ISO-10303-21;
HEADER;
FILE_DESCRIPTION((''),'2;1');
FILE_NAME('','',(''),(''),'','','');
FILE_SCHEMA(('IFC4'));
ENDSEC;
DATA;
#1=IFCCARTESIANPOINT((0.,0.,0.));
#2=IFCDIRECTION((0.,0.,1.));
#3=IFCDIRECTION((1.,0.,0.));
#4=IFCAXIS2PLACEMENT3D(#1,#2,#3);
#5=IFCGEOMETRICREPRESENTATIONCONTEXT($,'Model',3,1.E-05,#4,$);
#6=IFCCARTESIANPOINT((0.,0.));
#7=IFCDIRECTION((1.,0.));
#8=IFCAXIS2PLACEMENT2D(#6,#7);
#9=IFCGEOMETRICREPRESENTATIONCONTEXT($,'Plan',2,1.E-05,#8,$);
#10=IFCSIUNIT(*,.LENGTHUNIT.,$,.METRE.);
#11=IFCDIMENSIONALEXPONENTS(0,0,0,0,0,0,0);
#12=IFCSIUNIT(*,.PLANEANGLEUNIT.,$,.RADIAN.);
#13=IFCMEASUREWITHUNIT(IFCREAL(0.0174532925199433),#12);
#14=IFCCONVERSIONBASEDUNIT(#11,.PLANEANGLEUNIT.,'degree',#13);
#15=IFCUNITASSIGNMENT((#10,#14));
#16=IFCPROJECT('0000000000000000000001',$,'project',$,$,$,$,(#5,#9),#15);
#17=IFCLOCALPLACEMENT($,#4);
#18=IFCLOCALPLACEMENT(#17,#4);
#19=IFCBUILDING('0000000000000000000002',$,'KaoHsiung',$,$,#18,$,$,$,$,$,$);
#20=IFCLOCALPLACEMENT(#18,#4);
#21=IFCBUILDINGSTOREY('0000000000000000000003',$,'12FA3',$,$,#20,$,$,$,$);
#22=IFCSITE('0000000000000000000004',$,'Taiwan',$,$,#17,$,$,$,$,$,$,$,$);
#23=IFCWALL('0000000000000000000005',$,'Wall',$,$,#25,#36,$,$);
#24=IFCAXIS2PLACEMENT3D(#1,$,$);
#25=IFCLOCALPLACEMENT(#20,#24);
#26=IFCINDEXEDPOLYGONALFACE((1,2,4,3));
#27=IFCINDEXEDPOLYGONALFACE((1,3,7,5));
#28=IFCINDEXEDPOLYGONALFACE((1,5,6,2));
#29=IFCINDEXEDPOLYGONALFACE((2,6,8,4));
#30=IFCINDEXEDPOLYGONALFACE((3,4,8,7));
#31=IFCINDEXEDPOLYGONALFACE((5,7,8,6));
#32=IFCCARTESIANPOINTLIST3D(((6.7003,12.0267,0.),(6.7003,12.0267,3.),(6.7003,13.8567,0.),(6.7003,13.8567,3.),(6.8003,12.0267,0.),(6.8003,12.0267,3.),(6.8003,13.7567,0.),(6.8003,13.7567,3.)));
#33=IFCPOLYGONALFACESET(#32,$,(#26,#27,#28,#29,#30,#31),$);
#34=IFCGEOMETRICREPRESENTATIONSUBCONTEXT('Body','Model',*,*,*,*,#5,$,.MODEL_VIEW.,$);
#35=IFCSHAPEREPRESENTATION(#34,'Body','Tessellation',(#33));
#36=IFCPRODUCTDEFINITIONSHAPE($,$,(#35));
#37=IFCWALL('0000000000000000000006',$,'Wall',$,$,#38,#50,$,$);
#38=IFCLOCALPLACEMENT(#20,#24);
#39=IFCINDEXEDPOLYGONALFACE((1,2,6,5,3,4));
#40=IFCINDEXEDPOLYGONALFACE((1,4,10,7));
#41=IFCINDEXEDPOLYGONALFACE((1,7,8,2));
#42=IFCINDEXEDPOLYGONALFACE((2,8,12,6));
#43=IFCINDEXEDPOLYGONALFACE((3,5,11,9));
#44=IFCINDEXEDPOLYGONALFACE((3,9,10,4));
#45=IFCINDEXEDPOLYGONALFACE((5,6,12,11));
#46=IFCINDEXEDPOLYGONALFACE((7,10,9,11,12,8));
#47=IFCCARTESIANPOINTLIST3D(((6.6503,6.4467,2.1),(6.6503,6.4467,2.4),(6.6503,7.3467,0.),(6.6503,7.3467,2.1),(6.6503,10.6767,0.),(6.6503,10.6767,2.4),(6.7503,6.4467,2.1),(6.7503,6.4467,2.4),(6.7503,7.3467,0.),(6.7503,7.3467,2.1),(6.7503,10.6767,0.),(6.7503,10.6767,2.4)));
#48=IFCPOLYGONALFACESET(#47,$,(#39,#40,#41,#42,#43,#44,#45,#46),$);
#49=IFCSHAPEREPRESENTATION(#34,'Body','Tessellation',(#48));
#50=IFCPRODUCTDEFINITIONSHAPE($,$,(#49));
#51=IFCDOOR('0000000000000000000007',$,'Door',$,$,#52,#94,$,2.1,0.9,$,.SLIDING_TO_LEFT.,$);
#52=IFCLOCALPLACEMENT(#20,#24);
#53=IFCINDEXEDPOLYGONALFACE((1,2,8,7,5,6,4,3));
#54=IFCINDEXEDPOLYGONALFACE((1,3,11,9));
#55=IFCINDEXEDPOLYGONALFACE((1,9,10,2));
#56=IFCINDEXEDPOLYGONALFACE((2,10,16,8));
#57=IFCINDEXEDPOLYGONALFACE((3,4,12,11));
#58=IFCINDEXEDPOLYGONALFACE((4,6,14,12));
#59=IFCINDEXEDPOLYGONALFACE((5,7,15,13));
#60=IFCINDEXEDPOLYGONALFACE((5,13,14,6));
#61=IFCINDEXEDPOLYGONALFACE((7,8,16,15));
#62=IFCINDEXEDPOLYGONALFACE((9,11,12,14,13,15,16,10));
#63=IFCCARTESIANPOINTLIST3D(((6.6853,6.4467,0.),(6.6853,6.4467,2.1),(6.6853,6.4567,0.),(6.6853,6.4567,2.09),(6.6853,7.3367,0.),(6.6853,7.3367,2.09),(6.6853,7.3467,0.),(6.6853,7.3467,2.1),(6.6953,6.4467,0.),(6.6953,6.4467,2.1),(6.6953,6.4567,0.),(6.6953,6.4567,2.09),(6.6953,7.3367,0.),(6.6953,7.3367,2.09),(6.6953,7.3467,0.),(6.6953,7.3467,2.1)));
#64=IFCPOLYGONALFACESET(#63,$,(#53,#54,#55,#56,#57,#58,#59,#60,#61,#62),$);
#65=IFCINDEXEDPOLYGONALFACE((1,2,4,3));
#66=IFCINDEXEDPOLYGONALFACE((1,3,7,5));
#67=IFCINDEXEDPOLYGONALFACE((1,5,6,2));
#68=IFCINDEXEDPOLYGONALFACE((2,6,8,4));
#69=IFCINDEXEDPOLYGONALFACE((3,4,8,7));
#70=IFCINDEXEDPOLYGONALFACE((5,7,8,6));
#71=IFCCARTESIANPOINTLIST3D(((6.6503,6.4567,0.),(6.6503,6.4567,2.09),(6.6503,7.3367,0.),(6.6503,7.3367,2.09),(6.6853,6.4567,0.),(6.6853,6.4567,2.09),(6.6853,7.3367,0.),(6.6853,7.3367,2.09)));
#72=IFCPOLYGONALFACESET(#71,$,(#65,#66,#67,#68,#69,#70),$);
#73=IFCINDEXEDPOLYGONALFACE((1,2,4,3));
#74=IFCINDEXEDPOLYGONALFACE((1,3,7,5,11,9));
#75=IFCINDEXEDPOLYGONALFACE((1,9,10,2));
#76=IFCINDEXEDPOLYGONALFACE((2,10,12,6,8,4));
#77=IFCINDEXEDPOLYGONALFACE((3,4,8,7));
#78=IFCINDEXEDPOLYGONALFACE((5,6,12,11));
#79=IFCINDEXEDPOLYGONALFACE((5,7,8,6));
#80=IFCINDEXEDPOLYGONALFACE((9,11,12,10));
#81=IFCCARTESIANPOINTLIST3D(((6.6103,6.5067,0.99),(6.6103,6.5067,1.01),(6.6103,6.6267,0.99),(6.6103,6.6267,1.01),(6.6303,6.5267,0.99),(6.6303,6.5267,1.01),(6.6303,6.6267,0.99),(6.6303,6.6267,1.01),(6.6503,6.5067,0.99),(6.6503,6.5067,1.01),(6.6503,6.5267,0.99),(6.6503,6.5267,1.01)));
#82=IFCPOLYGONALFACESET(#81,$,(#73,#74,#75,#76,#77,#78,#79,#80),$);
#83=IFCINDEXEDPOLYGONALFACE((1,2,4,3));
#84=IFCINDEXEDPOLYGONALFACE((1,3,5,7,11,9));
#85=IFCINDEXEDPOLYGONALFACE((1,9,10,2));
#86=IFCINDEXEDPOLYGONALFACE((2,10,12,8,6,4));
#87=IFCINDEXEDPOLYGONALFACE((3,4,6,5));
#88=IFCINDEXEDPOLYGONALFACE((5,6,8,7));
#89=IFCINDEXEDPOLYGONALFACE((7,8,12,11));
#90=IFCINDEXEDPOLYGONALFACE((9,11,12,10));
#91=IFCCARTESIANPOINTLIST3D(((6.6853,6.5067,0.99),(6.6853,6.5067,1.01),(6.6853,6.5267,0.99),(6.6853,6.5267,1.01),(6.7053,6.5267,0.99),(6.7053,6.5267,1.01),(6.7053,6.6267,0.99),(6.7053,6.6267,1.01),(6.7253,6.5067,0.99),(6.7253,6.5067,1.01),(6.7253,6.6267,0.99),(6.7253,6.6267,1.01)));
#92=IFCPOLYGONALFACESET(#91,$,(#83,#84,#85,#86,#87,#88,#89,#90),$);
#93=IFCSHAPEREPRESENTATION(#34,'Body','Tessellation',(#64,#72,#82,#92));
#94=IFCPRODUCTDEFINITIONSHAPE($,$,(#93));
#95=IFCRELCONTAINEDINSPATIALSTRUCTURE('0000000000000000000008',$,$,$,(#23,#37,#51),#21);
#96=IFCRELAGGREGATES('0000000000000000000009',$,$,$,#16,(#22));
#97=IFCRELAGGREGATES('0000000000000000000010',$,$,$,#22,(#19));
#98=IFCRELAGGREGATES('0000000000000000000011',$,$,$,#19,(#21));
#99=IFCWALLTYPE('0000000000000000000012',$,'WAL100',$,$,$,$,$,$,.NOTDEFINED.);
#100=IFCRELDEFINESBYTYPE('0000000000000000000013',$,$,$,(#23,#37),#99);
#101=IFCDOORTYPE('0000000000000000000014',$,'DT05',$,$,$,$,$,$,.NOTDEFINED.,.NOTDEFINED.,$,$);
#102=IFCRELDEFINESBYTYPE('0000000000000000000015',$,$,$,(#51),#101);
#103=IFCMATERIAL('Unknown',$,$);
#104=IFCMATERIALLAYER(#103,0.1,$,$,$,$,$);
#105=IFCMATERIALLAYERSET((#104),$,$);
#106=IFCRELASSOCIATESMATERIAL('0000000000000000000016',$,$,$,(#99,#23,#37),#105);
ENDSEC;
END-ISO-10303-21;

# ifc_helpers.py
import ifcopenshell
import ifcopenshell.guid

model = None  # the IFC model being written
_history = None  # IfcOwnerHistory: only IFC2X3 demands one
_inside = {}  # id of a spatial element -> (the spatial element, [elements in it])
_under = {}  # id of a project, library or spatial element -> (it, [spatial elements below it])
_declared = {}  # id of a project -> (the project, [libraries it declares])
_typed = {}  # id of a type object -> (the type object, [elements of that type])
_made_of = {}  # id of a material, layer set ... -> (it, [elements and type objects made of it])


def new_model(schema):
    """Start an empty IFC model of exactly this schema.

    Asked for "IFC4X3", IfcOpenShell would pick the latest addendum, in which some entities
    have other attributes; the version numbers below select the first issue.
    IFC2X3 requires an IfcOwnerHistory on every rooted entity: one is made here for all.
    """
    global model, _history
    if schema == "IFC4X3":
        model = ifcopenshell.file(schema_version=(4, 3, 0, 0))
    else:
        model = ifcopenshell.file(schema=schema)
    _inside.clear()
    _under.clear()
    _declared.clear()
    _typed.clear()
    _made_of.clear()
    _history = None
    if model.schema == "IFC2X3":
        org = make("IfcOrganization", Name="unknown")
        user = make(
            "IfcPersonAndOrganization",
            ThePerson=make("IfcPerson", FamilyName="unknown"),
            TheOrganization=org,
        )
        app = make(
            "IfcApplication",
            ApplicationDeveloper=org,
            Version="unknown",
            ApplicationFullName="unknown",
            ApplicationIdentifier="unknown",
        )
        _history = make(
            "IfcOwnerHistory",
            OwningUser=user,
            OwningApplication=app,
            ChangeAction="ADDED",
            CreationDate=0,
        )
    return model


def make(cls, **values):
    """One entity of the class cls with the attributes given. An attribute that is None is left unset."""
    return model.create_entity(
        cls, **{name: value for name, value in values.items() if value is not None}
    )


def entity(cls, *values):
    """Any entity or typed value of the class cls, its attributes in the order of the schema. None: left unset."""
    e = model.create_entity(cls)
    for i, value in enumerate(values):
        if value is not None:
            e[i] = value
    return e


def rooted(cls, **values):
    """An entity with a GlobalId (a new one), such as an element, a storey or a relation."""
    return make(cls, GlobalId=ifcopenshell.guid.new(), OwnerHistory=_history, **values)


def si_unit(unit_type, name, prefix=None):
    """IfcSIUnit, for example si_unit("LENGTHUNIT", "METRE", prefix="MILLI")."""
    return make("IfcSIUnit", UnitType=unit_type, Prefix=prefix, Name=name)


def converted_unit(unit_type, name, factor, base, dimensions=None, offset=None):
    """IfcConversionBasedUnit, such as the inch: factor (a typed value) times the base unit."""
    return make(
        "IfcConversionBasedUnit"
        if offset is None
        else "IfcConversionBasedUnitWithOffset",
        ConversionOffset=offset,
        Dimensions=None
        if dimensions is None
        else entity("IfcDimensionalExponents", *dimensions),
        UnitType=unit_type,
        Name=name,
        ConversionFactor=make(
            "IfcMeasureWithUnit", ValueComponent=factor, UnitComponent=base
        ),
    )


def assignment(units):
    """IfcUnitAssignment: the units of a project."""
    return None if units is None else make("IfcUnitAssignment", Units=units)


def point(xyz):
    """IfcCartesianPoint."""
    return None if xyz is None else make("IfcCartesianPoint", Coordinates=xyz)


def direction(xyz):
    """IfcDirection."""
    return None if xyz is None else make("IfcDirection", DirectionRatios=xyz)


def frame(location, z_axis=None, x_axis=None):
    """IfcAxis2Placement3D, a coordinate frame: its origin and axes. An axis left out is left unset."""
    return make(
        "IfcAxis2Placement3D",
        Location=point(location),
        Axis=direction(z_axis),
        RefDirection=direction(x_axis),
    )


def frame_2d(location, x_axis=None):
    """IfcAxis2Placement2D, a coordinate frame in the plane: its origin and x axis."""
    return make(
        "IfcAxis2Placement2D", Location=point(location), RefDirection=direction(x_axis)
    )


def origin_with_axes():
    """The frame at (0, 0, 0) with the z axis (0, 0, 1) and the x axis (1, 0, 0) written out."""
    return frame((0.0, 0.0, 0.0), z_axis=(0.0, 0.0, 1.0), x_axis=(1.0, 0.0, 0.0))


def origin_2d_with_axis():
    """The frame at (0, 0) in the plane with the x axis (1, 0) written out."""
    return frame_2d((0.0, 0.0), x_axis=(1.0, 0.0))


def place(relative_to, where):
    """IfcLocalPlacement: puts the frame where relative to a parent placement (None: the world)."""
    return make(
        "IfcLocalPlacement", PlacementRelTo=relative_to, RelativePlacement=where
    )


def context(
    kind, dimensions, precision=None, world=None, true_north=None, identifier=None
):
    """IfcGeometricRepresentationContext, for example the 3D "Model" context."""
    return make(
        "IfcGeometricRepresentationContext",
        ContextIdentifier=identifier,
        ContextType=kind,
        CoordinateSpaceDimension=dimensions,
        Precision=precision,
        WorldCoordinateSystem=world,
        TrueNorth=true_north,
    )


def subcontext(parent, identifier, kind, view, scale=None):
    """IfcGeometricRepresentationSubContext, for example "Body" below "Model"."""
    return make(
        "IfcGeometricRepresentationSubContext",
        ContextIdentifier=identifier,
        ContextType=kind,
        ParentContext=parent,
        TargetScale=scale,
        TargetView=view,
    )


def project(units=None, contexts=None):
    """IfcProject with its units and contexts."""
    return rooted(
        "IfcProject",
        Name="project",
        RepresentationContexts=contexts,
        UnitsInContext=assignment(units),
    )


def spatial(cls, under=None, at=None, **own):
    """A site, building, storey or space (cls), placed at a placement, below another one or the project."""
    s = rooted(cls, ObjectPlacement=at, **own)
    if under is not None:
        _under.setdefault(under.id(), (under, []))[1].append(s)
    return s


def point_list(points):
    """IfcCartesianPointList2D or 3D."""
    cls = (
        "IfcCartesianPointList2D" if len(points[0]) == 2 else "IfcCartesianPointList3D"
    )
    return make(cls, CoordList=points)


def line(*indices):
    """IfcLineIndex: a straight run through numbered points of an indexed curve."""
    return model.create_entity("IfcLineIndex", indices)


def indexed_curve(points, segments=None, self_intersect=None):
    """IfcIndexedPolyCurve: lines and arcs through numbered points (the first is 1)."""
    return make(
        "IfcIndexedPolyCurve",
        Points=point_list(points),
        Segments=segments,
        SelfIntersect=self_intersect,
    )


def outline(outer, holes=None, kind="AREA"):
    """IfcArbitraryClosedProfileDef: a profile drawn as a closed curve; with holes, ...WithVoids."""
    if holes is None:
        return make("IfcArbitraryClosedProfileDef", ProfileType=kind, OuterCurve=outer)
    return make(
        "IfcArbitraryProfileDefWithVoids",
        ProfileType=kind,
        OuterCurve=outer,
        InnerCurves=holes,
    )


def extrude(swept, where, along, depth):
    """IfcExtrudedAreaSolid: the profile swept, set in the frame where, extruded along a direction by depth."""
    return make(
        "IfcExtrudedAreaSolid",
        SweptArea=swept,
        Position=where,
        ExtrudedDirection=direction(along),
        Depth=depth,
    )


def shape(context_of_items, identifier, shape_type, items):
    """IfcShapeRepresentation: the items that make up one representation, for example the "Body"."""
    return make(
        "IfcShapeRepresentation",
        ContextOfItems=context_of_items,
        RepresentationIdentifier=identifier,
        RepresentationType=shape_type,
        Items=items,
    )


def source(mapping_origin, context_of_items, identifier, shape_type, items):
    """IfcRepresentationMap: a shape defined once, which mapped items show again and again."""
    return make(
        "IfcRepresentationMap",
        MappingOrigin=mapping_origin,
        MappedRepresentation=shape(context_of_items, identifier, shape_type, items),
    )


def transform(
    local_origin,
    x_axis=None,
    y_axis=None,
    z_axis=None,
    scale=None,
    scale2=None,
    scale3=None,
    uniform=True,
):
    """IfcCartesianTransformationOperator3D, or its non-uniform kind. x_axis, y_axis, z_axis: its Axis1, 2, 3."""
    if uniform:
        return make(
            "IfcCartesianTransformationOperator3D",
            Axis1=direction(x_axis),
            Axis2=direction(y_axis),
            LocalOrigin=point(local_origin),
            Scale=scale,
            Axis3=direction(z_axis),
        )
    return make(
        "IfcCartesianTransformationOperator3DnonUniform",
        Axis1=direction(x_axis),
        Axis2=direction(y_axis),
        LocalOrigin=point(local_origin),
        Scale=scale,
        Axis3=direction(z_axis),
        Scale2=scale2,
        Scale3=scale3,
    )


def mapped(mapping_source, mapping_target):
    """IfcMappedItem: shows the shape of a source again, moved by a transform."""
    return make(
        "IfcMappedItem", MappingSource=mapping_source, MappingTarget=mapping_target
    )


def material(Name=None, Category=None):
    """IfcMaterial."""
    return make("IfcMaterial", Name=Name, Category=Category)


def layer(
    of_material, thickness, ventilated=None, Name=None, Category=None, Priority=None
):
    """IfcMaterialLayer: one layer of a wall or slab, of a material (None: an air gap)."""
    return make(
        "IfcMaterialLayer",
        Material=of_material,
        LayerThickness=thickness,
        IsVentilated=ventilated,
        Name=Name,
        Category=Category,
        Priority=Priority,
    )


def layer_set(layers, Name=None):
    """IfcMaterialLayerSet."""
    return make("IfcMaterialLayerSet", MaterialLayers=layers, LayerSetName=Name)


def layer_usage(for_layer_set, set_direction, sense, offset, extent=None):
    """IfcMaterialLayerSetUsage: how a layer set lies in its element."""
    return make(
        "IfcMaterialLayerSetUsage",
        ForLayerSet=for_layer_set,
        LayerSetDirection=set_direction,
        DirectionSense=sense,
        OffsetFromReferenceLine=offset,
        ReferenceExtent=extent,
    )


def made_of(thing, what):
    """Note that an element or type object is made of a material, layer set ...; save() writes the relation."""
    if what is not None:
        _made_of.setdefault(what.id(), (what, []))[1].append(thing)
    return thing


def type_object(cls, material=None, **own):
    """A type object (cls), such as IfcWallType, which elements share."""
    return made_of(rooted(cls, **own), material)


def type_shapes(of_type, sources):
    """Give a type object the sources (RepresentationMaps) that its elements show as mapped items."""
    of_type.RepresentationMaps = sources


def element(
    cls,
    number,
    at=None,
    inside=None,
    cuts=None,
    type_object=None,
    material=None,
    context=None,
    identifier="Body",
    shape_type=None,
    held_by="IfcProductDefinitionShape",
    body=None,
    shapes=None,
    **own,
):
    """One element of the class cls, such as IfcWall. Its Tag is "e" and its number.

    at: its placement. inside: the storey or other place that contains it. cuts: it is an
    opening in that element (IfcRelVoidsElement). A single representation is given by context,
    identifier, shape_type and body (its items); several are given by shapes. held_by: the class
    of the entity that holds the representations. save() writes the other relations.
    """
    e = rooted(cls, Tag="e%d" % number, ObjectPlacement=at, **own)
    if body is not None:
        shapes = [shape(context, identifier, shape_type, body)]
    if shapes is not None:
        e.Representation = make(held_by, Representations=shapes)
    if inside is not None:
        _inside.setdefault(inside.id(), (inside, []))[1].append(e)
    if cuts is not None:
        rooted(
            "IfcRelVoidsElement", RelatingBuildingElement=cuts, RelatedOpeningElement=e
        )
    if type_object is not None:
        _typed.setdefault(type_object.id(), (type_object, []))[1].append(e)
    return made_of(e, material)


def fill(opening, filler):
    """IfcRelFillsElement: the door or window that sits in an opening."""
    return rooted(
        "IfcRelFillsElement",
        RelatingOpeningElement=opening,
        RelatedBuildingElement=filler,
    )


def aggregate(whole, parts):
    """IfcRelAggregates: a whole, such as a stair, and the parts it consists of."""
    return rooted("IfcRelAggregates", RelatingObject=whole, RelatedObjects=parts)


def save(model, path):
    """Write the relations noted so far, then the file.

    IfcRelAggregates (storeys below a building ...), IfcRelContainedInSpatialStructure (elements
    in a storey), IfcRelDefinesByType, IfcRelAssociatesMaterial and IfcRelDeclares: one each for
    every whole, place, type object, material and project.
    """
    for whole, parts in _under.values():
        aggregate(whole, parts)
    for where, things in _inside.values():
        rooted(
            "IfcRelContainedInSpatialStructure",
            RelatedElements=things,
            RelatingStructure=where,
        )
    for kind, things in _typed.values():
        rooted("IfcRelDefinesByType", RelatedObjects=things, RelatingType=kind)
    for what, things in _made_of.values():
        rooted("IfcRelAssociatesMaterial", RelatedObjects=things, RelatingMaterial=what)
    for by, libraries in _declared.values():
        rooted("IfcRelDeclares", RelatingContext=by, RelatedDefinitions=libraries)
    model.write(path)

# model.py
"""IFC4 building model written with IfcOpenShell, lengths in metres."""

from ifc_helpers import new_model, entity, si_unit, converted_unit, frame, origin_with_axes, origin_2d_with_axis, place, context, subcontext, project, spatial, line, indexed_curve, outline, extrude, shape, source, transform, mapped, material, layer, layer_set, layer_usage, type_object, type_shapes, element, fill, save


model = new_model("IFC4")

# Units and contexts
model_context = context("Model", 3, precision=1e-05, world=origin_with_axes())
plan_context = context("Plan", 2, precision=1e-05, world=origin_2d_with_axis())
body_context_1 = subcontext(model_context, "Body", "Model", "MODEL_VIEW")
body_context_2 = subcontext(plan_context, "Body", "Plan", "PLAN_VIEW")
ifc_project = project(units=[si_unit("LENGTHUNIT", "METRE"), converted_unit("PLANEANGLEUNIT", "degree", entity("IfcReal", 0.0174532925199433), si_unit("PLANEANGLEUNIT", "RADIAN"), dimensions=[0, 0, 0, 0, 0, 0, 0])], contexts=[model_context, plan_context])

# Site, building, storey
site_placement = place(None, origin_with_axes())
site = spatial("IfcSite", under=ifc_project, at=site_placement, Name="Taiwan")
building_placement = place(site_placement, origin_with_axes())
building = spatial("IfcBuilding", under=site, at=building_placement, Name="KaoHsiung")
storey_placement = place(building_placement, origin_with_axes())
storey = spatial("IfcBuildingStorey", under=building, at=storey_placement, Name="12FA3")

# Shared definitions
ifc_material = material(Name="Unknown")

# Wall
ifc_layer_1 = layer(ifc_material, 0.1)
ifc_layer_set_1 = layer_set([ifc_layer_1])
wall_type_1 = type_object("IfcWallType", Name="WAL100", PredefinedType="NOTDEFINED", material=ifc_layer_set_1)
ifc_layer_usage_1 = layer_usage(ifc_layer_set_1, "AXIS2", "POSITIVE", 0.0)
wall_1_placement = place(storey_placement, frame((6.7003, 13.8567, 0.0), z_axis=(0.0, 0.0, 1.0), x_axis=(0.0, -1.0, 0.0)))
element("IfcWall", 1, at=wall_1_placement, inside=storey, type_object=wall_type_1, material=ifc_layer_usage_1, Name="Wall", context=body_context_1, shape_type="SweptSolid", body=[
    extrude(outline(indexed_curve([(0.0, 0.0), (0.1, 0.1), (1.8299, 0.1), (1.8299, 0.0)], segments=[line(1, 2, 3, 4, 1)])), origin_with_axes(), (0.0, 0.0, 1.0), 3.0),
])

# Wall, opening, door
ifc_layer_usage_2 = layer_usage(ifc_layer_set_1, "AXIS2", "POSITIVE", 0.0)
wall_2_placement = place(storey_placement, frame((6.6503, 10.6767, 0.0), z_axis=(0.0, 0.0, 1.0), x_axis=(0.0, -1.0, 0.0)))
wall_2 = element("IfcWall", 2, at=wall_2_placement, inside=storey, type_object=wall_type_1, material=ifc_layer_usage_2, Name="Wall", context=body_context_1, shape_type="SweptSolid", body=[
    extrude(outline(indexed_curve([(0.0, 0.0), (0.0, 0.1), (4.23, 0.1), (4.23, 0.0)], segments=[line(1, 2, 3, 4, 1)])), origin_with_axes(), (0.0, 0.0, 1.0), 2.4),
])
shared_shape_1 = source(origin_with_axes(), body_context_1, "Body", "SweptSolid", [
    extrude(outline(indexed_curve([(0.0, 0.0), (0.9, 0.0), (0.9, 2.1), (0.0, 2.1)], segments=[line(1, 2, 3, 4, 1)])), frame((0.0, -0.6, 0.0), z_axis=(0.0, -1.0, 0.0), x_axis=(1.0, 0.0, 0.0)), (0.0, 0.0, -1.0), 1.2),
])
opening_1_placement = place(wall_2_placement, frame((3.33, 0.0, 0.0), z_axis=(0.0, 0.0, 1.0), x_axis=(1.0, 0.0, 0.0)))
opening_1 = element("IfcOpeningElement", 3, at=opening_1_placement, cuts=wall_2, PredefinedType="OPENING", context=body_context_1, shape_type="MappedRepresentation", body=[
    mapped(shared_shape_1, transform((0.0, 0.0, 0.0), x_axis=(1.0, 0.0, 0.0), y_axis=(0.0, 1.0, 0.0), z_axis=(0.0, 0.0, 1.0), scale=1.0)),
])
door_type_1 = type_object("IfcDoorType", Name="DT05", OperationType="NOTDEFINED", PredefinedType="NOTDEFINED")
shared_shape_2 = source(origin_with_axes(), body_context_1, "Body", "SweptSolid", [
    extrude(outline(indexed_curve([(0.0, 0.0), (0.0, 2.1), (0.9, 2.1), (0.9, 0.0), (0.89, 0.0), (0.89, 2.09), (0.01, 2.09), (0.01, 0.0)], segments=[line(1, 2, 3, 4, 5, 6, 7, 8, 1)])), frame((0.0, 0.035, 0.0), z_axis=(0.0, -1.0, 0.0), x_axis=(1.0, 0.0, 0.0)), (0.0, 0.0, -1.0), 0.01),
    extrude(outline(indexed_curve([(0.0, 0.0), (0.88, 0.0), (0.88, 0.035), (0.0, 0.035)], segments=[line(1, 2, 3, 4, 1)])), frame((0.01, 0.0, 0.0), z_axis=(0.0, 0.0, 1.0), x_axis=(1.0, 0.0, 0.0)), (0.0, 0.0, 1.0), 2.09),
    extrude(outline(indexed_curve([(0.0, 0.0), (0.0, -0.04), (-0.12, -0.04), (-0.12, -0.02), (-0.02, -0.02), (-0.02, 0.0)], segments=[line(1, 2, 3, 4, 5, 6, 1)])), frame((0.84, 0.0, 0.99), z_axis=(0.0, 0.0, 1.0), x_axis=(1.0, 0.0, 0.0)), (0.0, 0.0, 1.0), 0.02),
    extrude(outline(indexed_curve([(0.0, 0.0), (0.0, 0.04), (-0.12, 0.04), (-0.12, 0.02), (-0.02, 0.02), (-0.02, 0.0)], segments=[line(1, 2, 3, 4, 5, 6, 1)])), frame((0.84, 0.035, 0.99), z_axis=(0.0, 0.0, 1.0), x_axis=(1.0, 0.0, 0.0)), (0.0, 0.0, 1.0), 0.02),
])
shared_shape_3 = source(origin_with_axes(), body_context_2, "Body", "Curve2D", [
    entity("IfcIndexedPolyCurve", entity("IfcCartesianPointList2D", [[0.0, 0.035], [0.01, 0.035], [0.01, 0.045], [0.0, 0.045]]), [entity("IfcLineIndex", [1, 2, 3, 4, 1])]),
    entity("IfcIndexedPolyCurve", entity("IfcCartesianPointList2D", [[0.9, 0.035], [0.89, 0.035], [0.89, 0.045], [0.9, 0.045]]), [entity("IfcLineIndex", [1, 2, 3, 4, 1])]),
    entity("IfcIndexedPolyCurve", entity("IfcCartesianPointList2D", [[-0.43, 0.0], [0.45, 0.0], [0.45, 0.035], [-0.43, 0.035]]), [entity("IfcLineIndex", [1, 2, 3, 4, 1])]),
])
type_shapes(door_type_1, [shared_shape_2, shared_shape_3])
door_1_placement = place(opening_1_placement, frame((0.0, 0.0, 0.0), z_axis=(0.0, 0.0, 1.0), x_axis=(1.0, 0.0, 0.0)))
door_1 = element("IfcDoor", 4, at=door_1_placement, inside=storey, type_object=door_type_1, Name="Door", OperationType="SLIDING_TO_LEFT", OverallHeight=2.1, OverallWidth=0.9, shapes=[
    shape(body_context_1, "Body", "MappedRepresentation", [mapped(shared_shape_2, transform((0.0, 0.0, 0.0), x_axis=(1.0, 0.0, 0.0), y_axis=(0.0, 1.0, 0.0), z_axis=(0.0, 0.0, 1.0), scale=1.0))]),
    shape(body_context_2, "Body", "MappedRepresentation", [mapped(shared_shape_3, transform((0.0, 0.0, 0.0), x_axis=(1.0, 0.0, 0.0), y_axis=(0.0, 1.0, 0.0), z_axis=(0.0, 0.0, 1.0), scale=1.0))]),
])
fill(opening_1, door_1)

save(model, "model.ifc")
